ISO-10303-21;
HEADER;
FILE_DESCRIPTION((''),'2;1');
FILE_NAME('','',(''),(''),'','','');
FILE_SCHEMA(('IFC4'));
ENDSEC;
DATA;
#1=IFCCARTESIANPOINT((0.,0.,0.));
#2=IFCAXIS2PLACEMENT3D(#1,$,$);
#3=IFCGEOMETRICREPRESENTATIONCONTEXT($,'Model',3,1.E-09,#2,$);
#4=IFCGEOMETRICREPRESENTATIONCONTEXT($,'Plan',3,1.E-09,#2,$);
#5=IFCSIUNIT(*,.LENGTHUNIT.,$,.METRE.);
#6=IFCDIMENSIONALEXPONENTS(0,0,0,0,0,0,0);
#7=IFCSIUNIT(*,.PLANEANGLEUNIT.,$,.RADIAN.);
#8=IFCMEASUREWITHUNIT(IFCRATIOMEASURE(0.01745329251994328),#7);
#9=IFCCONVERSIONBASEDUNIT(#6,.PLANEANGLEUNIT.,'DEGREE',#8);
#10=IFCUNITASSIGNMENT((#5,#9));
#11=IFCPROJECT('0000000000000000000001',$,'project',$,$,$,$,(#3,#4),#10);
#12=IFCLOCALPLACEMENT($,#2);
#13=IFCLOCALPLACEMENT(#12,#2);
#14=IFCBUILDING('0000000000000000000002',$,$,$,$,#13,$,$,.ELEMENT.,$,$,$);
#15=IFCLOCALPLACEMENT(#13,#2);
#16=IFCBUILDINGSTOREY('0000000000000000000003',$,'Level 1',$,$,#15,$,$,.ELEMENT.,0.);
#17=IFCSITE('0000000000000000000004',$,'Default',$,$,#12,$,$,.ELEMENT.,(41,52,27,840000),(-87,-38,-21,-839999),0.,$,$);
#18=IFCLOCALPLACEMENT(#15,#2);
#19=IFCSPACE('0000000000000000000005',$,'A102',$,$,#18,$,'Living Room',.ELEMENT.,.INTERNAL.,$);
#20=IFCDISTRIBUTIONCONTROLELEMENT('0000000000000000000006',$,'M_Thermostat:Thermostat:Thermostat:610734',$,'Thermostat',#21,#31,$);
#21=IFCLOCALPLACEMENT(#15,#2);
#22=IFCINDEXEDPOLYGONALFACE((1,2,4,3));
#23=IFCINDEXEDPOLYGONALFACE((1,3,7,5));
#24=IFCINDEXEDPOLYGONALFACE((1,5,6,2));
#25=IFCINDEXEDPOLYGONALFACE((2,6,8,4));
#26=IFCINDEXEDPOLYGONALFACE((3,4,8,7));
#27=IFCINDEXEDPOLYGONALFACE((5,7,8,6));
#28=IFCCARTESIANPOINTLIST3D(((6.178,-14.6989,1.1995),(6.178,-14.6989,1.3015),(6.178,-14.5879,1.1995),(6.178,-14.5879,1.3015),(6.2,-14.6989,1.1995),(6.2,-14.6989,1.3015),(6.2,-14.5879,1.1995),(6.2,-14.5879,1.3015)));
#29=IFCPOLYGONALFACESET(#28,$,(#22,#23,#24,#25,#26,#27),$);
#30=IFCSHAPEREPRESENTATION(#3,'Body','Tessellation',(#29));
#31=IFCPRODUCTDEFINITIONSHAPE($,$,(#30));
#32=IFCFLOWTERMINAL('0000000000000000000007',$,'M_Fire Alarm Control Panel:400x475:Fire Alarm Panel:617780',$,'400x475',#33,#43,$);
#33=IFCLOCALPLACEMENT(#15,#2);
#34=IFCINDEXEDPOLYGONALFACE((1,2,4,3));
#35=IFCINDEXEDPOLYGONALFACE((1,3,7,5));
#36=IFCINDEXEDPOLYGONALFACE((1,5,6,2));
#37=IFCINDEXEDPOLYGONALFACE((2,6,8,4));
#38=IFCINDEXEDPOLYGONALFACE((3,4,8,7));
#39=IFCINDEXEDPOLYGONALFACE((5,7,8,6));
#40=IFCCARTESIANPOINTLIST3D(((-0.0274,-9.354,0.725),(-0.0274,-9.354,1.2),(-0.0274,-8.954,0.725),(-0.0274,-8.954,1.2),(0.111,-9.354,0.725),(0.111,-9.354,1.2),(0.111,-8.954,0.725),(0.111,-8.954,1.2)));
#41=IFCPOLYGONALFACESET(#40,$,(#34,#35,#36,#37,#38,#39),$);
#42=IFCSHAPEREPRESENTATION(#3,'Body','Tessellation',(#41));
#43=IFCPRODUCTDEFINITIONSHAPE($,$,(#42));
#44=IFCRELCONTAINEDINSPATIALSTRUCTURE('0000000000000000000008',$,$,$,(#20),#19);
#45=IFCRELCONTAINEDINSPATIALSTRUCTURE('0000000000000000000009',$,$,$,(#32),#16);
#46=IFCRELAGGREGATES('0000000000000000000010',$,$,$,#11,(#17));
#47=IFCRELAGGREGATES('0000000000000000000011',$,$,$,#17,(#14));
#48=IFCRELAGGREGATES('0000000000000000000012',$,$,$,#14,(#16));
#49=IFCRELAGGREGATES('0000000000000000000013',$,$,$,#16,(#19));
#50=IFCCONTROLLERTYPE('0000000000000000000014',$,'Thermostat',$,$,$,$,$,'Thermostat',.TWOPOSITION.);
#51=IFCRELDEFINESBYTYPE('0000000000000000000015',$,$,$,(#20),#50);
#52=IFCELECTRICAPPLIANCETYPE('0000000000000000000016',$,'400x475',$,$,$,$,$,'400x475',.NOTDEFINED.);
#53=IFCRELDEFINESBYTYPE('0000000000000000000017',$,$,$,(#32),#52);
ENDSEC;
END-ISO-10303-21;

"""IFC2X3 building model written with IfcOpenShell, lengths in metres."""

from ifc_helpers import new_model, entity, si_unit, converted_unit, frame, origin, origin_2d_with_axis, place, context, project, spatial, rectangle, extrude, source, transform, mapped, type_object, type_shapes, element, save


model = new_model("IFC2X3")

# Units and contexts
model_context = context("Model", 3, precision=1e-09, world=origin())
plan_context = context("Plan", 3, precision=1e-09, world=origin())
ifc_project = project(units=[si_unit("LENGTHUNIT", "METRE"), converted_unit("PLANEANGLEUNIT", "DEGREE", entity("IfcRatioMeasure", 0.01745329251994328), si_unit("PLANEANGLEUNIT", "RADIAN"), dimensions=[0, 0, 0, 0, 0, 0, 0])], contexts=[model_context, plan_context])

# Site, building, storey
site_placement = place(None, origin())
site = spatial("IfcSite", under=ifc_project, at=site_placement, Name="Default", CompositionType="ELEMENT", RefLatitude=(41, 52, 27, 840000), RefLongitude=(-87, -38, -21, -839999), RefElevation=0.0)
building_placement = place(site_placement, origin())
building = spatial("IfcBuilding", under=site, at=building_placement, CompositionType="ELEMENT")
storey_placement = place(building_placement, origin())
storey = spatial("IfcBuildingStorey", under=building, at=storey_placement, Name="Level 1", CompositionType="ELEMENT", Elevation=0.0)

# Shared definitions
space_1_placement = place(storey_placement, origin())
space_1 = spatial("IfcSpace", under=storey, at=space_1_placement, Name="A102", LongName="Living Room", CompositionType="ELEMENT", InteriorOrExteriorSpace="INTERNAL")

# Distribution control element
controller_type = type_object("IfcControllerType", Name="Thermostat", ElementType="Thermostat", PredefinedType="TWOPOSITION")
shared_shape_1 = source(origin(), model_context, "Body", "SweptSolid", [
    extrude(rectangle(XDim=0.102, YDim=0.111, at=origin_2d_with_axis()), frame((0.0, -0.051, 0.0), z_axis=(0.0, 0.0, 1.0), x_axis=(0.0, 1.0, 0.0)), (0.0, 0.0, 1.0), 0.022),
])
type_shapes(controller_type, [shared_shape_1])
distribution_control_element_placement = place(space_1_placement, frame((6.2, -14.6434, 1.3015), z_axis=(-1.0, 0.0, 0.0), x_axis=(0.0, -1.0, 0.0)))
element("IfcDistributionControlElement", 1, at=distribution_control_element_placement, inside=space_1, type_object=controller_type, Name="M_Thermostat:Thermostat:Thermostat:610734", ObjectType="Thermostat", context=model_context, shape_type="MappedRepresentation", body=[
    mapped(shared_shape_1, transform((0.0, 0.0, 0.0), scale=1.0)),
])

# Flow terminal
electric_appliance_type_1 = type_object("IfcElectricApplianceType", Name="400x475", ElementType="400x475", PredefinedType="NOTDEFINED")
shared_shape_2 = source(origin(), model_context, "Body", "SweptSolid", [
    extrude(rectangle(XDim=0.4, YDim=0.475, at=origin_2d_with_axis()), frame((0.0004, -0.2375, -0.111), z_axis=(0.0, 0.0, 1.0), x_axis=(-1.0, 0.0, 0.0)), (0.0, 0.0, 1.0), 0.1384),
])
type_shapes(electric_appliance_type_1, [shared_shape_2])
flow_terminal_1_placement = place(storey_placement, frame((0.0, -9.1536, 1.2), z_axis=(-1.0, 0.0, 0.0), x_axis=(0.0, -1.0, 0.0)))
element("IfcFlowTerminal", 2, at=flow_terminal_1_placement, inside=storey, type_object=electric_appliance_type_1, Name="M_Fire Alarm Control Panel:400x475:Fire Alarm Panel:617780", ObjectType="400x475", context=model_context, shape_type="MappedRepresentation", body=[
    mapped(shared_shape_2, transform((0.0, 0.0, 0.0), scale=1.0)),
])

save(model, "model.ifc")
